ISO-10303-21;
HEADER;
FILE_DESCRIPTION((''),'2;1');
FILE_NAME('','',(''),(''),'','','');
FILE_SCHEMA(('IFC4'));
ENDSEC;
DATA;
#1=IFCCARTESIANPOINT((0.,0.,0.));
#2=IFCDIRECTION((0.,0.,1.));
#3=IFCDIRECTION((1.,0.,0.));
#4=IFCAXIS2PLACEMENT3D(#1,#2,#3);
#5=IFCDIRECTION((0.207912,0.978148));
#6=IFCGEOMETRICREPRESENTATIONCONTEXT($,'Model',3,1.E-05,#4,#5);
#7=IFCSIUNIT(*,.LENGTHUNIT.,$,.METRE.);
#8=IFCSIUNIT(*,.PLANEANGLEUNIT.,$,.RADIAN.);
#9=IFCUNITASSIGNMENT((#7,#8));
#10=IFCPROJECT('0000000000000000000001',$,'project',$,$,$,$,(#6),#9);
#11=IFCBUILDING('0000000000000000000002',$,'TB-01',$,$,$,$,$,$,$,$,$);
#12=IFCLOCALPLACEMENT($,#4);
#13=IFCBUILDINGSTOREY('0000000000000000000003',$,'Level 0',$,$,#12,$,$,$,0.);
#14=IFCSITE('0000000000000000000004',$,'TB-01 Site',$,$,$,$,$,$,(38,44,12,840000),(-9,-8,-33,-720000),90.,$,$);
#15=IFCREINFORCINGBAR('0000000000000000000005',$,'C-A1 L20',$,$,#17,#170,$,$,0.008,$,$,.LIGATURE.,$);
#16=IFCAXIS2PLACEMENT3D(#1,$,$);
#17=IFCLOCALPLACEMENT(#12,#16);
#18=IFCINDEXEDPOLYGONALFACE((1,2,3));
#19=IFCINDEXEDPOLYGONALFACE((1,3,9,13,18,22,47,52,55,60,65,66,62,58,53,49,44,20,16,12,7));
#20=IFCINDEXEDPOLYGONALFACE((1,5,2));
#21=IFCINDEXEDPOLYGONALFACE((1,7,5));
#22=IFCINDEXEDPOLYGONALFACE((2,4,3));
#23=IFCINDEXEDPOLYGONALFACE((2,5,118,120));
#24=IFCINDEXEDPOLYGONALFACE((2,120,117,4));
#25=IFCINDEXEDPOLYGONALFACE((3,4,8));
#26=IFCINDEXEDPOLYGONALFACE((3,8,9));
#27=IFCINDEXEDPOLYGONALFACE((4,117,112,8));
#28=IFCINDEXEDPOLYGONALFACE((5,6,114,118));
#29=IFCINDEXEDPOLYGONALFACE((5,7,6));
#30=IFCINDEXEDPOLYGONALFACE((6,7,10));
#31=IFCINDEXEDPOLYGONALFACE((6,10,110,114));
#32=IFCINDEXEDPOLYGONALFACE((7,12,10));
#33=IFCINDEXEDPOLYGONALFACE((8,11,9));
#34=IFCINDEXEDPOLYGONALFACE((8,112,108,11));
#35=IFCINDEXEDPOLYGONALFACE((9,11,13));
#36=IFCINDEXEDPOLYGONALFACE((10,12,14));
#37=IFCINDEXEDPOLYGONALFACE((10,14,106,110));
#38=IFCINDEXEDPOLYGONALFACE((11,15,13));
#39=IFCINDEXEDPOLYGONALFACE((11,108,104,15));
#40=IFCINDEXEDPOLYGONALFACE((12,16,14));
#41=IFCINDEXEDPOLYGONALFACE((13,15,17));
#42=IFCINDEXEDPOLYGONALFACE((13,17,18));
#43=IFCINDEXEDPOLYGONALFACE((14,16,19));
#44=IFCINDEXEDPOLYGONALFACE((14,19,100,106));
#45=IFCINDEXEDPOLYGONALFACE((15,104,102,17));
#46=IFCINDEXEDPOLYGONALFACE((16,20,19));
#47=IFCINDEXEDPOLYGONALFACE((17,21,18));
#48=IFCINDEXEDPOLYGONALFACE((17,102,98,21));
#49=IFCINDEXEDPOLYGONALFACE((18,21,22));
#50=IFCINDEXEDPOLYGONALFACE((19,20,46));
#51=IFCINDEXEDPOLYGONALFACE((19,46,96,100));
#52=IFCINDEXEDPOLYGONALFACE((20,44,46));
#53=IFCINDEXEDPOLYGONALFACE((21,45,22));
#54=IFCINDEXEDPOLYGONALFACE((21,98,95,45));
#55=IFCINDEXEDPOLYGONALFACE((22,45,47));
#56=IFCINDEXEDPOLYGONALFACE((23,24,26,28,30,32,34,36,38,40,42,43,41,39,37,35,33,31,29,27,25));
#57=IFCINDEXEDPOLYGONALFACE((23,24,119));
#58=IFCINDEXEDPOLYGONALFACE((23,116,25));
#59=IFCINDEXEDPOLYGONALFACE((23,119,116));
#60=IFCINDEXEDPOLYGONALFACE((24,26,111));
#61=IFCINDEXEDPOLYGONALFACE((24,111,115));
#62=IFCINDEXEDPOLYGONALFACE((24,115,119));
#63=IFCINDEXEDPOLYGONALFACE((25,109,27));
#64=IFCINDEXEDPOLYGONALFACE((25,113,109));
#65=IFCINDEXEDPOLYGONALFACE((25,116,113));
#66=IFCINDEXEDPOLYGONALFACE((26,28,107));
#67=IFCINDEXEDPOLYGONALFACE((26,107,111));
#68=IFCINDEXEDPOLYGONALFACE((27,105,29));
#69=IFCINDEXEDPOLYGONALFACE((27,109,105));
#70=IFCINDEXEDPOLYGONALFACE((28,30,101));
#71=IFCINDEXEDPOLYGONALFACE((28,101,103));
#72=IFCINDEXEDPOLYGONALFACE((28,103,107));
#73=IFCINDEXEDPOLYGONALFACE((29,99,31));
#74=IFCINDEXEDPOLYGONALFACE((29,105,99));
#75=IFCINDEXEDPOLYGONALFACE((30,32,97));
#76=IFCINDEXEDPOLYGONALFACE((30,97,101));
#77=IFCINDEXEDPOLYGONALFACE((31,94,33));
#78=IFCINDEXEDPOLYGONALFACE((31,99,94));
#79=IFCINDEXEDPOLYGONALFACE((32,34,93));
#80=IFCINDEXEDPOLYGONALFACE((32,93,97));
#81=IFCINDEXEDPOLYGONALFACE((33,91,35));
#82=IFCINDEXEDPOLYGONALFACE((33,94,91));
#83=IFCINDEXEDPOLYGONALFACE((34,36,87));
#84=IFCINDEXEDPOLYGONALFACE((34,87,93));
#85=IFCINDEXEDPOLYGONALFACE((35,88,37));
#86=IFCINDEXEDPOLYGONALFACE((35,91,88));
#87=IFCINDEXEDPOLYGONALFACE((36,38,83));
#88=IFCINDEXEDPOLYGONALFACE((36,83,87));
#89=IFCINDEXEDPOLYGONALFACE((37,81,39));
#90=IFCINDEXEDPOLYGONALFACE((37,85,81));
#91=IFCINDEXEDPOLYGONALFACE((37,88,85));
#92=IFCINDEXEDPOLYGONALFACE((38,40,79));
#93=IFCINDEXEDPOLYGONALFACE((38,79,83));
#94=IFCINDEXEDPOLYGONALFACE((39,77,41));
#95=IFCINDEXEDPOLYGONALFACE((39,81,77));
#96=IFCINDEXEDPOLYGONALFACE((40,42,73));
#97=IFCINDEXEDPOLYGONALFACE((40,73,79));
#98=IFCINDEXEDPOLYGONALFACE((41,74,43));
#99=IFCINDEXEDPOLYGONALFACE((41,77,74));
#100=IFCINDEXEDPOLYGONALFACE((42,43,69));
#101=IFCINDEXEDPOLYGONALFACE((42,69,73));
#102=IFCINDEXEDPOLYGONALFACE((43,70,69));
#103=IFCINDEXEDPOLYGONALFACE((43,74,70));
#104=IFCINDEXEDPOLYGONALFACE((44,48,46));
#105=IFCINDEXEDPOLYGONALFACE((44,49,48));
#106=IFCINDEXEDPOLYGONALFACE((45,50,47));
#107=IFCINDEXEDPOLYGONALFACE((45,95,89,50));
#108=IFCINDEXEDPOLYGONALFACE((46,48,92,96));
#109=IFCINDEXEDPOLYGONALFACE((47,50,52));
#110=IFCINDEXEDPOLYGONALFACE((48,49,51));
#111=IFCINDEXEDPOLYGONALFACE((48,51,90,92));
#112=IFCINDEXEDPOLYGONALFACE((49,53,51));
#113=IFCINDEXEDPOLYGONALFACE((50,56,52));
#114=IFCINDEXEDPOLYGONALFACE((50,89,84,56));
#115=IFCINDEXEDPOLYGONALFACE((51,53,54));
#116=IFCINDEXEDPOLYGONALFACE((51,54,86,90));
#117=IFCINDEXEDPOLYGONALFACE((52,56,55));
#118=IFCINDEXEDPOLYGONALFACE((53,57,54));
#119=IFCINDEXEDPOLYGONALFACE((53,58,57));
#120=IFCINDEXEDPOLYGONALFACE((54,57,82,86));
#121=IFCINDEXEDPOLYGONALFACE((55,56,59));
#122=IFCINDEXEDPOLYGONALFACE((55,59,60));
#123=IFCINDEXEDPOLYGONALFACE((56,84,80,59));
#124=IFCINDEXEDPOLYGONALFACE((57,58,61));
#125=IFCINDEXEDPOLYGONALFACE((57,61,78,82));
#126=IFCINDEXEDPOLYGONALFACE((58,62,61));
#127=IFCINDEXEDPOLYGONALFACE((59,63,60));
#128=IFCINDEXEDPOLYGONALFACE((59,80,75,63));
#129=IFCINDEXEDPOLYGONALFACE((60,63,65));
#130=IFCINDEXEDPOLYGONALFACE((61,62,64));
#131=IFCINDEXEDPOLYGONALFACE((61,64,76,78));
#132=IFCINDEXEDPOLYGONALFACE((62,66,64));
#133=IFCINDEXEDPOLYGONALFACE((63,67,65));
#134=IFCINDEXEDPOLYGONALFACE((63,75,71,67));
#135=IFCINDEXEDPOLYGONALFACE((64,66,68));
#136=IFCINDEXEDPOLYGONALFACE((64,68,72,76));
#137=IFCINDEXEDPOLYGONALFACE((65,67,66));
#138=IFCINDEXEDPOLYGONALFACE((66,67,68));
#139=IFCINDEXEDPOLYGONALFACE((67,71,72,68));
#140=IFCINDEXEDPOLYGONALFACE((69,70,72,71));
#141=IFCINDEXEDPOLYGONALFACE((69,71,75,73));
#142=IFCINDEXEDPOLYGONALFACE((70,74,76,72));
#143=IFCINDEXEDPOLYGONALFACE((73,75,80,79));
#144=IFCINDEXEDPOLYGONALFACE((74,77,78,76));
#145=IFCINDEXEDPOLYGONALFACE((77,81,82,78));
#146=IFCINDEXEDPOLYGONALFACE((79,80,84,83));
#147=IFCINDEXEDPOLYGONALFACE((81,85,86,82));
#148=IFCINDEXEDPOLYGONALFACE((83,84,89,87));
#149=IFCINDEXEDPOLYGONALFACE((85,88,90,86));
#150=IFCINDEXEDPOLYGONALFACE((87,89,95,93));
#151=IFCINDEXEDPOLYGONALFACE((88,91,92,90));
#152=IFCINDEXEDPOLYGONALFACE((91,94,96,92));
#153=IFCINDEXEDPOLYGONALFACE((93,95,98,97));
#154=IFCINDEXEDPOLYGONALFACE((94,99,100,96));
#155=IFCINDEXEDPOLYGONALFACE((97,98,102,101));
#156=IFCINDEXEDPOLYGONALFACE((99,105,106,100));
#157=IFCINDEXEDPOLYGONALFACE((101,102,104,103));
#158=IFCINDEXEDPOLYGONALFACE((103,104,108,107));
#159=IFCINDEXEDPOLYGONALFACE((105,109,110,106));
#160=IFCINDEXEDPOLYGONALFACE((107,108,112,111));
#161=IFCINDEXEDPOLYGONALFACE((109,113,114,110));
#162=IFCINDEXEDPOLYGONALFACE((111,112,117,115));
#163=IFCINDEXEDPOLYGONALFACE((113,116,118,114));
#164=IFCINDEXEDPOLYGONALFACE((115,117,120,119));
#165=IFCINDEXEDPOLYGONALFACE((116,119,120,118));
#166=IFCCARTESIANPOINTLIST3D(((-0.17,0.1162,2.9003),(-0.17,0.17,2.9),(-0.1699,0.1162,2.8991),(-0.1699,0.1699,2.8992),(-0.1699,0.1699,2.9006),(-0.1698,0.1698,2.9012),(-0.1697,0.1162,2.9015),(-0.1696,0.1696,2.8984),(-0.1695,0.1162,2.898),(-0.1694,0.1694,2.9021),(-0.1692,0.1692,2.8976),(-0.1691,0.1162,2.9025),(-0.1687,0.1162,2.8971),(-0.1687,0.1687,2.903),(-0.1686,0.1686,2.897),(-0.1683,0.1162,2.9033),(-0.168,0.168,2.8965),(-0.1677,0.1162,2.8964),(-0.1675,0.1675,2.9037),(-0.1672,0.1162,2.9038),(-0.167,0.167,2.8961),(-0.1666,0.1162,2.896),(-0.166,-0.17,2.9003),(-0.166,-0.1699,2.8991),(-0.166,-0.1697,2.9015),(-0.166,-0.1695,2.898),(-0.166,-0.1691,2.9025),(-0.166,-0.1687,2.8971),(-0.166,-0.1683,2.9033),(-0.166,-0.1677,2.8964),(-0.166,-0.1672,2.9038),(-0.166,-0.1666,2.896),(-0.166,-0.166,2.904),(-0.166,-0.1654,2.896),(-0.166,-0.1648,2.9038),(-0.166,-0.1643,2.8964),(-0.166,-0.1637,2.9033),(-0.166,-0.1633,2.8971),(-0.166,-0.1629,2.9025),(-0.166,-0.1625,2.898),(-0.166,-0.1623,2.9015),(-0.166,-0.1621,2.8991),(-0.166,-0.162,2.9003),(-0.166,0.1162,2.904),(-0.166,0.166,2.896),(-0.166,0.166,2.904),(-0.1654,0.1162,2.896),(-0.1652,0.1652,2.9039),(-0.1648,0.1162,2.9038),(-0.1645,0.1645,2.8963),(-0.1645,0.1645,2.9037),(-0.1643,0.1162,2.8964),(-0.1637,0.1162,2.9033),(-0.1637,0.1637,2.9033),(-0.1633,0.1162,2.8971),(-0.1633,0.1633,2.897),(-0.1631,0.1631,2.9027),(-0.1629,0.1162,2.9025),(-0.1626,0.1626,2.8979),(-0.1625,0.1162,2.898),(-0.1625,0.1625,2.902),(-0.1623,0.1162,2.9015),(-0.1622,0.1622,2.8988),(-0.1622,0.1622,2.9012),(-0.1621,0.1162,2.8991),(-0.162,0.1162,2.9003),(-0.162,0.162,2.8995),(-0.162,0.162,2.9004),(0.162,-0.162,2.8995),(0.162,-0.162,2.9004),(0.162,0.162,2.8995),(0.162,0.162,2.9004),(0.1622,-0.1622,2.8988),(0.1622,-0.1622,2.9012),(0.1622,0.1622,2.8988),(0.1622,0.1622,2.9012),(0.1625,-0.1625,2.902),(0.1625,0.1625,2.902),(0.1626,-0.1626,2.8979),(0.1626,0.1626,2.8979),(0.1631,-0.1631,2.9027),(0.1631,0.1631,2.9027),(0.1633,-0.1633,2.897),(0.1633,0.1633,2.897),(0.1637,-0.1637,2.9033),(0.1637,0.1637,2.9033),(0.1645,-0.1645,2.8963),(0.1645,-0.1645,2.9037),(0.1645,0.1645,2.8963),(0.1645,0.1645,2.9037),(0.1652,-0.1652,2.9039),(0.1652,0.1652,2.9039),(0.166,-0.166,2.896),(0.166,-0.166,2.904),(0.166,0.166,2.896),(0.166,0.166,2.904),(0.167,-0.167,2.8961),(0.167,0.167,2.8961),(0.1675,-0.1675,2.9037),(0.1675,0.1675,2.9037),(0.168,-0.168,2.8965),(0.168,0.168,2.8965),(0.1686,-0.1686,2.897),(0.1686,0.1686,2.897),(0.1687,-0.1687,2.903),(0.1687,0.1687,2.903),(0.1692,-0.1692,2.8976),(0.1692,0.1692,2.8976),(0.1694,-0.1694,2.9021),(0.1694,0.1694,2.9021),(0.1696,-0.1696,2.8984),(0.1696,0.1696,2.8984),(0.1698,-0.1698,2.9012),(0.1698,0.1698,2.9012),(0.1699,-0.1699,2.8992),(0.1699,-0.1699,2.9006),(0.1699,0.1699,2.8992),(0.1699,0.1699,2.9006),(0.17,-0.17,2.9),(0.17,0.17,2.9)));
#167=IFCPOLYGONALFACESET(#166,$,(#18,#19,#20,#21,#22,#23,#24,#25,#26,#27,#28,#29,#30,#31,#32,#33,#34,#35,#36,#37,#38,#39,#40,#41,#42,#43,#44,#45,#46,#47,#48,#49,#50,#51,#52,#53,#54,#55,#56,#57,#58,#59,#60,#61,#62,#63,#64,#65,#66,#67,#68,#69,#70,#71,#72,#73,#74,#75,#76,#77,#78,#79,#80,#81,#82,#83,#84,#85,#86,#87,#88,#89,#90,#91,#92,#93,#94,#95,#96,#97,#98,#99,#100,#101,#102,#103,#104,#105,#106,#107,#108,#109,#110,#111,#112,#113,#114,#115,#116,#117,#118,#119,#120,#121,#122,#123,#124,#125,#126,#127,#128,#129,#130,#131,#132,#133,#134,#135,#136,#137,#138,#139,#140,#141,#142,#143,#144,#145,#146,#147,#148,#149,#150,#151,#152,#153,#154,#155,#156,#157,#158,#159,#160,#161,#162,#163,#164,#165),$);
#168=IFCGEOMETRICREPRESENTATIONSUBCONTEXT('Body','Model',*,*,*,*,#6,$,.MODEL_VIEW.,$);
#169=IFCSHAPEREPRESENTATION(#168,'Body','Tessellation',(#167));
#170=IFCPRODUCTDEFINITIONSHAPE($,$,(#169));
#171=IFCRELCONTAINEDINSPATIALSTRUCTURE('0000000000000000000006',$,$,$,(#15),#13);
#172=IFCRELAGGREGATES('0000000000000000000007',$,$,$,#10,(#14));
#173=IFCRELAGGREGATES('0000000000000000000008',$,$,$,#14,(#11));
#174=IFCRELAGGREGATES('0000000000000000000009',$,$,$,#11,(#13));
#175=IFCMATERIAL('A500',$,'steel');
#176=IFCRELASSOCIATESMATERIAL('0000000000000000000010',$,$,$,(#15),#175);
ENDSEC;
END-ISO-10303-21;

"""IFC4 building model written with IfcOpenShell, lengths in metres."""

from ifc_helpers import new_model, entity, si_unit, direction, origin_with_axes, place, context, subcontext, project, spatial, material, element, save


model = new_model("IFC4")

# Units and contexts
model_context = context("Model", 3, precision=1e-05, world=origin_with_axes(), true_north=direction((0.207912, 0.978148)))
body_context = subcontext(model_context, "Body", "Model", "MODEL_VIEW")
ifc_project = project(units=[si_unit("LENGTHUNIT", "METRE"), si_unit("PLANEANGLEUNIT", "RADIAN")], contexts=[model_context])

# Site, building, storey
site = spatial("IfcSite", under=ifc_project, Name="TB-01 Site", RefLatitude=(38, 44, 12, 840000), RefLongitude=(-9, -8, -33, -720000), RefElevation=90.0)
building = spatial("IfcBuilding", under=site, Name="TB-01")
storey_placement = place(None, origin_with_axes())
storey = spatial("IfcBuildingStorey", under=building, at=storey_placement, Name="Level 0", Elevation=0.0)

# Reinforcing bar
ifc_material_1 = material(Name="A500", Category="steel")
reinforcing_bar_1_placement = place(storey_placement, origin_with_axes())
element("IfcReinforcingBar", 1, at=reinforcing_bar_1_placement, inside=storey, material=ifc_material_1, Name="C-A1 L20", NominalDiameter=0.008, PredefinedType="LIGATURE", context=body_context, shape_type="AdvancedSweptSolid", body=[
    entity("IfcSweptDiskSolid", entity("IfcPolyline", [entity("IfcCartesianPoint", [-0.166, -0.166, 2.9]), entity("IfcCartesianPoint", [0.166, -0.166, 2.9]), entity("IfcCartesianPoint", [0.166, 0.166, 2.9]), entity("IfcCartesianPoint", [-0.166, 0.166, 2.9]), entity("IfcCartesianPoint", [-0.166, 0.1162, 2.9])]), 0.004),
])

save(model, "model.ifc")
